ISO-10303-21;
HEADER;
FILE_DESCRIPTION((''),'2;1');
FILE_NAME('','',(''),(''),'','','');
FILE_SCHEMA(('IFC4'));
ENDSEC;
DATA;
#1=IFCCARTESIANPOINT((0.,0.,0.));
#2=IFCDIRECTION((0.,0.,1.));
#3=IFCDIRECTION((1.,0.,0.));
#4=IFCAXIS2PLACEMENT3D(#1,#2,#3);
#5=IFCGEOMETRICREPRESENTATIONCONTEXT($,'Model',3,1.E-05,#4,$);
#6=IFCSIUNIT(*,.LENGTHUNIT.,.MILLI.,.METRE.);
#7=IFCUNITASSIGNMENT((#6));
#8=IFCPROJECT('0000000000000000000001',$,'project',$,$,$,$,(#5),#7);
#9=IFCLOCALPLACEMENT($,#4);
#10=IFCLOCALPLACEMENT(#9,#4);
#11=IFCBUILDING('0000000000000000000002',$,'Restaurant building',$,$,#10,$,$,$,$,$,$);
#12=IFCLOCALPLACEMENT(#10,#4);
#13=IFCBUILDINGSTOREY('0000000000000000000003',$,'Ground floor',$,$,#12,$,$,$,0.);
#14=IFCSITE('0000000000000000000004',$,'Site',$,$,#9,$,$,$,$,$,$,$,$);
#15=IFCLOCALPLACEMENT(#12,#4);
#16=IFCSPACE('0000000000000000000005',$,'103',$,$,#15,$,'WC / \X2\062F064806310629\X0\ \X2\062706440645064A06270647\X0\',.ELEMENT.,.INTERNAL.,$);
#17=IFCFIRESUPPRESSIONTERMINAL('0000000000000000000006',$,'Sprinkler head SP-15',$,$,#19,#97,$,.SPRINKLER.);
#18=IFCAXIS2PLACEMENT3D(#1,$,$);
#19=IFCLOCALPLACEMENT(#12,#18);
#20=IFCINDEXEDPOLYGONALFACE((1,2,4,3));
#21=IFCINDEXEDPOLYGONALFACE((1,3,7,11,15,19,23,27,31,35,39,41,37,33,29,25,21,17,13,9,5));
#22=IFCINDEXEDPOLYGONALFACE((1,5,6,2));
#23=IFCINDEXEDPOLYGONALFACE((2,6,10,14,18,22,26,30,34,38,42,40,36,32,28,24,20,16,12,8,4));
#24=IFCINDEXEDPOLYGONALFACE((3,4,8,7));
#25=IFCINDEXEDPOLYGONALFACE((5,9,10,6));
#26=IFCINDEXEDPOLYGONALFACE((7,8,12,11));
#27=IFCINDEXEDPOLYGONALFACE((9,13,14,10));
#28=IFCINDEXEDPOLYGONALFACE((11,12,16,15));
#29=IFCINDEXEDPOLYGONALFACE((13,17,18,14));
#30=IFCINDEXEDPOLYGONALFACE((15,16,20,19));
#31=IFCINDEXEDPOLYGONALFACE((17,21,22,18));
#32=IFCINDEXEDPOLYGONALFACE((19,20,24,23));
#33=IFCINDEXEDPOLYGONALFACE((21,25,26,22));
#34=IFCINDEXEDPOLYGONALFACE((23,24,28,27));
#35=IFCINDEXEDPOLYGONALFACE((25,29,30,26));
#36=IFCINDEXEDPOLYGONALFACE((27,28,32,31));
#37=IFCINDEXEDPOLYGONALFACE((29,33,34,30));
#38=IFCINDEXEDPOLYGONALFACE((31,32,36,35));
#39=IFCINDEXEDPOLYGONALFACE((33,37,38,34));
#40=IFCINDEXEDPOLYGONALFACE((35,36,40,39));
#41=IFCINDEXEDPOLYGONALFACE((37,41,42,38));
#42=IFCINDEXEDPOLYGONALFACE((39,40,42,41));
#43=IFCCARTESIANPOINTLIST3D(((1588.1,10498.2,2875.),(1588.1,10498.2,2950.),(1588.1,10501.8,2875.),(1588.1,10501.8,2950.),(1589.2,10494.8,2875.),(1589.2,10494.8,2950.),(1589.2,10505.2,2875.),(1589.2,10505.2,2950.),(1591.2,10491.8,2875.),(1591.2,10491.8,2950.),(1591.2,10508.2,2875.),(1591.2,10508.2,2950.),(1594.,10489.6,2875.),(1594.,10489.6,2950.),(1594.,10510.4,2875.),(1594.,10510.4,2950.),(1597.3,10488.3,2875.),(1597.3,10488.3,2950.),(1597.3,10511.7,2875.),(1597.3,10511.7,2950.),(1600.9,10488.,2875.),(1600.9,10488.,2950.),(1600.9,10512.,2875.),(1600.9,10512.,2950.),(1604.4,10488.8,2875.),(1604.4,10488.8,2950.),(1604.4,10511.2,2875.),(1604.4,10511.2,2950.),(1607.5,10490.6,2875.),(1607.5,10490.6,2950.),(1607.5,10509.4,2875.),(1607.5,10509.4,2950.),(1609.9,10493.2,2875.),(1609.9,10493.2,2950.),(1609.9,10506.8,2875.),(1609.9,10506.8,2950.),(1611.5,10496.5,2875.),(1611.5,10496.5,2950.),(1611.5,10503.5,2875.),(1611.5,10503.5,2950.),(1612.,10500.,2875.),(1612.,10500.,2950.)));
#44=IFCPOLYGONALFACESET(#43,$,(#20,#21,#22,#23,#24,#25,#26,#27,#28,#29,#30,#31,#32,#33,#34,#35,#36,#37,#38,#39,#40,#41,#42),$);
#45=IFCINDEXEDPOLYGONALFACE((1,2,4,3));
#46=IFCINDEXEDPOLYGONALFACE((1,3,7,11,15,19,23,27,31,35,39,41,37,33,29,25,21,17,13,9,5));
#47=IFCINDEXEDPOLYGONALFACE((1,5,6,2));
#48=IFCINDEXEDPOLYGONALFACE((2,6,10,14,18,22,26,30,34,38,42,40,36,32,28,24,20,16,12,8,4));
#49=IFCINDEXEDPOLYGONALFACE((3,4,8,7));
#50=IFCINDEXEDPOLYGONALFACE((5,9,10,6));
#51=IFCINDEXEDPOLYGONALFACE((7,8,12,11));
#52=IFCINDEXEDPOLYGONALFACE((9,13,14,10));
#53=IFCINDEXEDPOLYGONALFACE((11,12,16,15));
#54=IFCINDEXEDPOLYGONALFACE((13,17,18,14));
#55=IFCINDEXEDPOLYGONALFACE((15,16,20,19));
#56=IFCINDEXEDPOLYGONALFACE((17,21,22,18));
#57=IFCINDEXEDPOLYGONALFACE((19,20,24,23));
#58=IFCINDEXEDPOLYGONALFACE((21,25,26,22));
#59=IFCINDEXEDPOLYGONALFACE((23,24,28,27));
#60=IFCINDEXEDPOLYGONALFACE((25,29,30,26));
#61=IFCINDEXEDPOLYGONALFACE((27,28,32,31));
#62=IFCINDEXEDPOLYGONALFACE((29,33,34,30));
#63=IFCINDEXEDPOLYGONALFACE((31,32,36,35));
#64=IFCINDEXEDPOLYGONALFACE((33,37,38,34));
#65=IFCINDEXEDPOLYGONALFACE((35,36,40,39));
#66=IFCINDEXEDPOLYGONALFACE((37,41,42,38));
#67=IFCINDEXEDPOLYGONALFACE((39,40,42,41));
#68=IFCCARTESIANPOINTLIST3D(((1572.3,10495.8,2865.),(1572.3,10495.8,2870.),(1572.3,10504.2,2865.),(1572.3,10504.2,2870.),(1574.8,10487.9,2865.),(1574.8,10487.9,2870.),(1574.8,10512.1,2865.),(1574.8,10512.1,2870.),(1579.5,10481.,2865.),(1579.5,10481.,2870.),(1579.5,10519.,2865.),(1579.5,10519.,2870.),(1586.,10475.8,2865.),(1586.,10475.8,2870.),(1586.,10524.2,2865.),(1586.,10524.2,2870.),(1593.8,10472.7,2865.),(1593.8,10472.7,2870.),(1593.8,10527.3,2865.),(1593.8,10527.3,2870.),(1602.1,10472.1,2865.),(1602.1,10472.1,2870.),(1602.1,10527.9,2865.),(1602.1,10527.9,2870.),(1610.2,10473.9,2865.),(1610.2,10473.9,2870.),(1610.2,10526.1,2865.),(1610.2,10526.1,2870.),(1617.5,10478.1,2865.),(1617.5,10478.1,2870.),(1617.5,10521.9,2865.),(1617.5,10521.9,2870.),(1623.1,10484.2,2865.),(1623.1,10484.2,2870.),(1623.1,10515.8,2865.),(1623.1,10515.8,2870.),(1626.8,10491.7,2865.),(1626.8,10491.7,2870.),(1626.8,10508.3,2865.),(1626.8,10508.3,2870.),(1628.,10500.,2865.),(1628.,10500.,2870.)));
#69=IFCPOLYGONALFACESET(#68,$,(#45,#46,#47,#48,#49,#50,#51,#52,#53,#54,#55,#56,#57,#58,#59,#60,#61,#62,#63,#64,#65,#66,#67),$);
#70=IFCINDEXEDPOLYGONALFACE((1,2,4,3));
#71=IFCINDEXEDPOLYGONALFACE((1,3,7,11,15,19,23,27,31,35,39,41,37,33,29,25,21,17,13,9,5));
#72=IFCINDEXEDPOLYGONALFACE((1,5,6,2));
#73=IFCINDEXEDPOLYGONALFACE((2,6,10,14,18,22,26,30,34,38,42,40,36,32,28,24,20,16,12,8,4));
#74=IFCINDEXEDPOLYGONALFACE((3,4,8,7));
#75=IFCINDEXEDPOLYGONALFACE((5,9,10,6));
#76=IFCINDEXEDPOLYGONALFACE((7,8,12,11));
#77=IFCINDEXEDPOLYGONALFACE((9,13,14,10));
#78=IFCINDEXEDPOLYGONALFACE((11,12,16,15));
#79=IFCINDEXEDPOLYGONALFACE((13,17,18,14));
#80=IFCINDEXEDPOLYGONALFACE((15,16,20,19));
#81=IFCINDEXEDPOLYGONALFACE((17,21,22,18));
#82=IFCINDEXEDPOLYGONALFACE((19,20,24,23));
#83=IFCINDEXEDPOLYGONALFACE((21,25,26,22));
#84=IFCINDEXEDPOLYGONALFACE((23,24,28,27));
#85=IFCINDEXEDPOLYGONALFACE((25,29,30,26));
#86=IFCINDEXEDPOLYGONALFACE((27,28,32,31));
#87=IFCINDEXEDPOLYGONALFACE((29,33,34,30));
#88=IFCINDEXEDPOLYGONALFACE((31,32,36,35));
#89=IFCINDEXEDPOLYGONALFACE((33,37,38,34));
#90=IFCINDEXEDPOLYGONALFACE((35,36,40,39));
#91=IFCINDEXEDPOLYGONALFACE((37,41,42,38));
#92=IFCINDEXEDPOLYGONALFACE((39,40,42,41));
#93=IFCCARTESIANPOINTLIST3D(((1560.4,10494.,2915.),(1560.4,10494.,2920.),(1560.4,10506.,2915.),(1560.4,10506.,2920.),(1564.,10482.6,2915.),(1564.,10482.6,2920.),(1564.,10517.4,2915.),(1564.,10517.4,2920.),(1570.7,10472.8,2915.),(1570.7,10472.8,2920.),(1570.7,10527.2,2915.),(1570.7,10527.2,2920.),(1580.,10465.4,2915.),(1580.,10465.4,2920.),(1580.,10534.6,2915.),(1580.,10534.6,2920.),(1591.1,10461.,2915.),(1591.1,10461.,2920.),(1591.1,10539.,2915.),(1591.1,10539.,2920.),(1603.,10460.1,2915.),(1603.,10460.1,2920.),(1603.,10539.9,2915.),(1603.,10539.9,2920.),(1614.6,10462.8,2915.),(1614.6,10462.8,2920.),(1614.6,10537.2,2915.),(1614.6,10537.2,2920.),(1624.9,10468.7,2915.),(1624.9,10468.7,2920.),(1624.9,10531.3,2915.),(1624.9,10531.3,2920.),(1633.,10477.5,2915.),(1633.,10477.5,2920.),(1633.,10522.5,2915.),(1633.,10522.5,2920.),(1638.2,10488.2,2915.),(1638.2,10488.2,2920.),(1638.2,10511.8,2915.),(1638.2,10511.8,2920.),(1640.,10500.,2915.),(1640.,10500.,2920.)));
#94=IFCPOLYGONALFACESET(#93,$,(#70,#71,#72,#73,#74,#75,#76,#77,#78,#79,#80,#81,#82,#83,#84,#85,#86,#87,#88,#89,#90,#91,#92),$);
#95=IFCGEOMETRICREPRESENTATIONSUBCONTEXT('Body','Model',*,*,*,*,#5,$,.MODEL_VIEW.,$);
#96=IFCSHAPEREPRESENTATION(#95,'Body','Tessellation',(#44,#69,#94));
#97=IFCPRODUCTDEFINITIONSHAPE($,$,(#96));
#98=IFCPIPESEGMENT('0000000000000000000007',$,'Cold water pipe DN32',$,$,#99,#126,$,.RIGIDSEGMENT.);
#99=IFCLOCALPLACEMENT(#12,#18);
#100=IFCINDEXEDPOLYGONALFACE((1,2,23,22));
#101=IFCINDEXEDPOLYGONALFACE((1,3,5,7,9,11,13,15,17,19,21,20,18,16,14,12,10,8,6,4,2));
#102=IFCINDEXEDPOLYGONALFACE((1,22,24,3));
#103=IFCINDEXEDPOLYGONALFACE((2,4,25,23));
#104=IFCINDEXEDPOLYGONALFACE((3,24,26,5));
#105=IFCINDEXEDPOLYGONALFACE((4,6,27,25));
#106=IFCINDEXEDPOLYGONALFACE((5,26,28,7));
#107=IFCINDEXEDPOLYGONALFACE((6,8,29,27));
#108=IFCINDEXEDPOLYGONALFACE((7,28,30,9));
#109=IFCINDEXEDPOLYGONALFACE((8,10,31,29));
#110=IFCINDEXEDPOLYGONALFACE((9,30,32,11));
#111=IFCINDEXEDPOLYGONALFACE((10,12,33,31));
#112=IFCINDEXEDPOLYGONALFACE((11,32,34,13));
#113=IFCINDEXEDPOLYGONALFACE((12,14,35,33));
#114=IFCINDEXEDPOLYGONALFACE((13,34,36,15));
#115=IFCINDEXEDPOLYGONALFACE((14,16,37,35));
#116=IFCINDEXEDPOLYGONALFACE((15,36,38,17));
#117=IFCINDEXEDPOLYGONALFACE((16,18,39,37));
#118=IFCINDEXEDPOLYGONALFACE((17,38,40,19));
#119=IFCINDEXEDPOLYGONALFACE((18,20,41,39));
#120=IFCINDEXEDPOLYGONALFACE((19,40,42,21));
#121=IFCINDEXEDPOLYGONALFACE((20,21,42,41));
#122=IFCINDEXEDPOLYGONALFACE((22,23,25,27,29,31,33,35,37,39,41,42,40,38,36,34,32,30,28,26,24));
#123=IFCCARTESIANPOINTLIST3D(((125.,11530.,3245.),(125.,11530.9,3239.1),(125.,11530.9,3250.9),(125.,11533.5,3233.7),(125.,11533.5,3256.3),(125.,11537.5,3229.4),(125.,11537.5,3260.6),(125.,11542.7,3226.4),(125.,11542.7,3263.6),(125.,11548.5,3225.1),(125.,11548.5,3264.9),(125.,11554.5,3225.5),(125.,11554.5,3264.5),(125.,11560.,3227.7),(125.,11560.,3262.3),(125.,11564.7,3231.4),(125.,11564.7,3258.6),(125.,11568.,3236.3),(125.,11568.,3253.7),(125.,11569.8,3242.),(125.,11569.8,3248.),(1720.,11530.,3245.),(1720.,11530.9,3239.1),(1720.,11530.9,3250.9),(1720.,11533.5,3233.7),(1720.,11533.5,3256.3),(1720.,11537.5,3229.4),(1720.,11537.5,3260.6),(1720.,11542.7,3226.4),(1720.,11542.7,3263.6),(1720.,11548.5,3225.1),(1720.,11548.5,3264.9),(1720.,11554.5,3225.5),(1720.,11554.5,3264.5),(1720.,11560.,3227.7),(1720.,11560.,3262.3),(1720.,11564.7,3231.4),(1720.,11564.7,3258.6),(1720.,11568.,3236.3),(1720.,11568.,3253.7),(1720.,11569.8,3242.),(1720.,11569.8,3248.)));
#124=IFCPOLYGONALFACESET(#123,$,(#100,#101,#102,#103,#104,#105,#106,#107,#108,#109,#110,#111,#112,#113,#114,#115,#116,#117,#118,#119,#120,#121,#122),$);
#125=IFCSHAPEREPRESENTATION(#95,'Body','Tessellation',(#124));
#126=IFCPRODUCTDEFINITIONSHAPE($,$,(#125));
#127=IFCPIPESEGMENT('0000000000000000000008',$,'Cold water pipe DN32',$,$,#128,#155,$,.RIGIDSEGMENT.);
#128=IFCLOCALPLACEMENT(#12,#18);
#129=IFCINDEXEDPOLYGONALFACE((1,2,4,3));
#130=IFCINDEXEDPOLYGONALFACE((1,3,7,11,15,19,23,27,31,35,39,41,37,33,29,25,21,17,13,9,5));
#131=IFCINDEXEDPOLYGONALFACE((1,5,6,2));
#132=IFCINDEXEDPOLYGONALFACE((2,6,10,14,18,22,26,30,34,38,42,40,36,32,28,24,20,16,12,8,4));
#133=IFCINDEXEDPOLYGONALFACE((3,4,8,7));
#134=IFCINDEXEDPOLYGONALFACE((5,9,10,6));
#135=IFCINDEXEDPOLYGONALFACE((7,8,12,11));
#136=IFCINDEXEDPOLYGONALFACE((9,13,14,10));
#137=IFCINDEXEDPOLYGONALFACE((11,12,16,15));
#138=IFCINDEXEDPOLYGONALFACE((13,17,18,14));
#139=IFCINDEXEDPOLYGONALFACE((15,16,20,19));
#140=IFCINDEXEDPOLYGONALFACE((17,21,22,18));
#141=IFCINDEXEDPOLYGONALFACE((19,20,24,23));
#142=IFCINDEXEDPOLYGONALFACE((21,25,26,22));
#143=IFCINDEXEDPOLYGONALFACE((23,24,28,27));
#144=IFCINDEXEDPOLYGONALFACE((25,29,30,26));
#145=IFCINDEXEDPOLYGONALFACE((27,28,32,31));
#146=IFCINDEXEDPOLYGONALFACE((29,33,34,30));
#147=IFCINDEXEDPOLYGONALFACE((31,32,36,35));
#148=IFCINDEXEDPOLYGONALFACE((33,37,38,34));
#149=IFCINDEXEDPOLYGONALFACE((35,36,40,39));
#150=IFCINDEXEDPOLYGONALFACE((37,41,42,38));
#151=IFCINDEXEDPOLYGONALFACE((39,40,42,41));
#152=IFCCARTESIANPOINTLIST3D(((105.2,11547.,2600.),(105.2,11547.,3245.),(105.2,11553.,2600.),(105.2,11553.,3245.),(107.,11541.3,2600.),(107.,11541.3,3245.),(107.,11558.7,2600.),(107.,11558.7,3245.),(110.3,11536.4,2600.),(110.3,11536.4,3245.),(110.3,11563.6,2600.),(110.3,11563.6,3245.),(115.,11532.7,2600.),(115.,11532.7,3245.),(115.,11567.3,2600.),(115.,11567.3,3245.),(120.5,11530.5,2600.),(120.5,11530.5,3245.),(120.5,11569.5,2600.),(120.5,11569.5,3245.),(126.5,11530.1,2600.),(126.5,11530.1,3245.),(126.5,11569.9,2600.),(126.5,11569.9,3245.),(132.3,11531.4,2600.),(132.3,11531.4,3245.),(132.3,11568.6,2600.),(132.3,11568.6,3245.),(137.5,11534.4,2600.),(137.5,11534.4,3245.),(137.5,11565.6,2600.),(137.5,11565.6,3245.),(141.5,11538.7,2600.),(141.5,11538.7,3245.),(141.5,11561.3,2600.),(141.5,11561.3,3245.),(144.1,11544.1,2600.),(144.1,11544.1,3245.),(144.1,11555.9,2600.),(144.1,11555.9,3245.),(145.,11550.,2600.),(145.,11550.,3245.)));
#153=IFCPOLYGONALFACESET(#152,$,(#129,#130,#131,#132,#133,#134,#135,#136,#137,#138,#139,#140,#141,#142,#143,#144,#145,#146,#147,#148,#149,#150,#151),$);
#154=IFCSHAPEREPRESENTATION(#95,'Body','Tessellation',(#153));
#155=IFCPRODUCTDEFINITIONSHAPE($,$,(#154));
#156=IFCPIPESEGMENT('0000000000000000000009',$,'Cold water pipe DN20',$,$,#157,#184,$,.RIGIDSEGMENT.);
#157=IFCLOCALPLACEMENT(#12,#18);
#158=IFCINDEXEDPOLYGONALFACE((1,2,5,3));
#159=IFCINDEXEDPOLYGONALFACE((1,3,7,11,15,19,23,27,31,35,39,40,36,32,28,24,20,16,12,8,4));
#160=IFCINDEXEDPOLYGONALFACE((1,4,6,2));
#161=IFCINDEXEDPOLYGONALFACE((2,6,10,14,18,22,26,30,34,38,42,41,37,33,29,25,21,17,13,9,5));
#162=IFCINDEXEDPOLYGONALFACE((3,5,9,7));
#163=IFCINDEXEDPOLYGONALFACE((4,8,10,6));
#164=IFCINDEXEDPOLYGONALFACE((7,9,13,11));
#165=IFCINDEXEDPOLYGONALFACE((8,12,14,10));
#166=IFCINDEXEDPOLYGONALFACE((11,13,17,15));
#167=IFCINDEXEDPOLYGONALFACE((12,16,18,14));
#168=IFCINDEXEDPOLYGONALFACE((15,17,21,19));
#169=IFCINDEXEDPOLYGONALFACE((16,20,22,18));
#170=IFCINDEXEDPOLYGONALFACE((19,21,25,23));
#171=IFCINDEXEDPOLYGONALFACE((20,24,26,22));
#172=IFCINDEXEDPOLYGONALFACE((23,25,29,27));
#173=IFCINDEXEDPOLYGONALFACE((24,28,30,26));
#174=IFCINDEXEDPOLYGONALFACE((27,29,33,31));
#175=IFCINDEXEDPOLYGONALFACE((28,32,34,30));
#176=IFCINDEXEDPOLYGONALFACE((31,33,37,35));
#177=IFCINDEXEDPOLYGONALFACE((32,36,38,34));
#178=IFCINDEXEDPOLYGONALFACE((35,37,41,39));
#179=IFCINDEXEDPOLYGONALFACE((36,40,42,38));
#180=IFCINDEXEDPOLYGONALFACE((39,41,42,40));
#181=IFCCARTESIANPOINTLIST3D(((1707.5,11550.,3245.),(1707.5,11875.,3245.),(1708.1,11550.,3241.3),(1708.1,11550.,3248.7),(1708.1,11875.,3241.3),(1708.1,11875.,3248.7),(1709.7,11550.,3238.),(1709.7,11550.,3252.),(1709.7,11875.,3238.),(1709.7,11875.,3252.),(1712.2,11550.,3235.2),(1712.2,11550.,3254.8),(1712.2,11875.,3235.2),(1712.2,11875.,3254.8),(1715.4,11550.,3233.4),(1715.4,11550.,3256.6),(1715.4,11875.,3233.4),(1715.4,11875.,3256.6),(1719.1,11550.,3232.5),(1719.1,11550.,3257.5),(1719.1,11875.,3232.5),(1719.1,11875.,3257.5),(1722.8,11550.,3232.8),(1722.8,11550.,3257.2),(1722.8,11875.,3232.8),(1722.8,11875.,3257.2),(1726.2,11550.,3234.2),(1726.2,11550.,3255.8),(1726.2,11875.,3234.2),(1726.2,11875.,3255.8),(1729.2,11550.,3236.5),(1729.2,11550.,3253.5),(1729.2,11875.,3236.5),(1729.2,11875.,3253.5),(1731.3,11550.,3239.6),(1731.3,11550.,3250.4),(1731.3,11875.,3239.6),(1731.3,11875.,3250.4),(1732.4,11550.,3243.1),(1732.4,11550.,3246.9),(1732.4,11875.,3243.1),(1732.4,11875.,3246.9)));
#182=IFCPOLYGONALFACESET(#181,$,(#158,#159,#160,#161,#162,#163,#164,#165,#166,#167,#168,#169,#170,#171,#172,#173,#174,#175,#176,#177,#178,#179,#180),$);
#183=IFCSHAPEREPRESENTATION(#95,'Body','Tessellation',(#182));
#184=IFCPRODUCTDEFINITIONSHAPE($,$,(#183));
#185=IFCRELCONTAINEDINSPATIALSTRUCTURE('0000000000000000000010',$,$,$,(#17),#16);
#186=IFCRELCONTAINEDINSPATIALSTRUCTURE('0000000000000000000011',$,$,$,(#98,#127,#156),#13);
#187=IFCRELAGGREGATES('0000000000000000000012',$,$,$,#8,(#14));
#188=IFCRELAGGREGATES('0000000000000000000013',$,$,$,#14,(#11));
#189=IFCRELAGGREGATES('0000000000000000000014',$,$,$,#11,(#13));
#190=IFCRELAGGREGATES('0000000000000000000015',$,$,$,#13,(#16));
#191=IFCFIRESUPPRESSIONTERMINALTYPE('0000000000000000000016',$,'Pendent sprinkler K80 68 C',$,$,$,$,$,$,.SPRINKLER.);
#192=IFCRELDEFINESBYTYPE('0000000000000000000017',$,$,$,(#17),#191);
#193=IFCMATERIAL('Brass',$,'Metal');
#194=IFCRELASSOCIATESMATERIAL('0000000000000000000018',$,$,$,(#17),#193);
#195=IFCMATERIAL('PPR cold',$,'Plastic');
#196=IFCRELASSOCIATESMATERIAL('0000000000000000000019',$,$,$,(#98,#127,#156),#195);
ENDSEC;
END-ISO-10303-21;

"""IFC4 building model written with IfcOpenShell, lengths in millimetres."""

from ifc_helpers import new_model, si_unit, frame, origin, origin_with_axes, origin_2d, place, context, subcontext, project, spatial, circle, extrude, source, transform, mapped, material, type_object, type_shapes, element, save


model = new_model("IFC4")

# Units and contexts
model_context = context("Model", 3, precision=1e-05, world=origin_with_axes())
body_context = subcontext(model_context, "Body", "Model", "MODEL_VIEW")
ifc_project = project(units=[si_unit("LENGTHUNIT", "METRE", prefix="MILLI")], contexts=[model_context])

# Site, building, storey, space
site_placement = place(None, origin_with_axes())
site = spatial("IfcSite", under=ifc_project, at=site_placement, Name="Site")
building_placement = place(site_placement, origin_with_axes())
building = spatial("IfcBuilding", under=site, at=building_placement, Name="Restaurant building")
storey_placement = place(building_placement, origin_with_axes())
storey = spatial("IfcBuildingStorey", under=building, at=storey_placement, Name="Ground floor", Elevation=0.0)
space_placement = place(storey_placement, origin_with_axes())
space = spatial("IfcSpace", under=storey, at=space_placement, Name="103", LongName="WC / دورة المياه", CompositionType="ELEMENT", PredefinedType="INTERNAL")

# Fire suppression terminal
ifc_material_1 = material(Name="Brass", Category="Metal")
fire_suppression_terminal_type = type_object("IfcFireSuppressionTerminalType", Name="Pendent sprinkler K80 68 C", PredefinedType="SPRINKLER")
shared_shape = source(origin(), body_context, "Body", "SweptSolid", [
    extrude(circle(Radius=12.0, at=origin_2d()), frame((0.0, 0.0, -75.0)), (0.0, 0.0, 1.0), 75.0),
    extrude(circle(Radius=28.0, at=origin_2d()), frame((0.0, 0.0, -85.0)), (0.0, 0.0, 1.0), 5.0),
    extrude(circle(Radius=40.0, at=origin_2d()), frame((0.0, 0.0, -35.0)), (0.0, 0.0, 1.0), 5.0),
])
type_shapes(fire_suppression_terminal_type, [shared_shape])
fire_suppression_terminal_placement = place(storey_placement, frame((1600.0, 10500.0, 2950.0)))
element("IfcFireSuppressionTerminal", 1, at=fire_suppression_terminal_placement, inside=space, type_object=fire_suppression_terminal_type, material=ifc_material_1, Name="Sprinkler head SP-15", PredefinedType="SPRINKLER", context=body_context, shape_type="MappedRepresentation", body=[
    mapped(shared_shape, transform((0.0, 0.0, 0.0))),
])

# Pipe segments
ifc_material_2 = material(Name="PPR cold", Category="Plastic")
pipe_segment_1_placement = place(storey_placement, frame((1720.0, 11550.0, 3245.0)))
element("IfcPipeSegment", 2, at=pipe_segment_1_placement, inside=storey, material=ifc_material_2, Name="Cold water pipe DN32", PredefinedType="RIGIDSEGMENT", context=body_context, shape_type="SweptSolid", body=[
    extrude(circle(Radius=20.0, at=origin_2d()), frame((0.0, 0.0, 0.0), z_axis=(-1.0, 0.0, 0.0), x_axis=(0.0, -1.0, 0.0)), (0.0, 0.0, 1.0), 1595.0),
])
pipe_segment_2_placement = place(storey_placement, frame((125.0, 11550.0, 3245.0)))
element("IfcPipeSegment", 3, at=pipe_segment_2_placement, inside=storey, material=ifc_material_2, Name="Cold water pipe DN32", PredefinedType="RIGIDSEGMENT", context=body_context, shape_type="SweptSolid", body=[
    extrude(circle(Radius=20.0, at=origin_2d()), frame((0.0, 0.0, 0.0), z_axis=(0.0, 0.0, -1.0), x_axis=(1.0, 0.0, 0.0)), (0.0, 0.0, 1.0), 645.0),
])
pipe_segment_3_placement = place(storey_placement, frame((1720.0, 11550.0, 3245.0)))
element("IfcPipeSegment", 4, at=pipe_segment_3_placement, inside=storey, material=ifc_material_2, Name="Cold water pipe DN20", PredefinedType="RIGIDSEGMENT", context=body_context, shape_type="SweptSolid", body=[
    extrude(circle(Radius=12.5, at=origin_2d()), frame((0.0, 0.0, 0.0), z_axis=(0.0, 1.0, 0.0), x_axis=(-1.0, 0.0, 0.0)), (0.0, 0.0, 1.0), 325.0),
])

save(model, "model.ifc")
